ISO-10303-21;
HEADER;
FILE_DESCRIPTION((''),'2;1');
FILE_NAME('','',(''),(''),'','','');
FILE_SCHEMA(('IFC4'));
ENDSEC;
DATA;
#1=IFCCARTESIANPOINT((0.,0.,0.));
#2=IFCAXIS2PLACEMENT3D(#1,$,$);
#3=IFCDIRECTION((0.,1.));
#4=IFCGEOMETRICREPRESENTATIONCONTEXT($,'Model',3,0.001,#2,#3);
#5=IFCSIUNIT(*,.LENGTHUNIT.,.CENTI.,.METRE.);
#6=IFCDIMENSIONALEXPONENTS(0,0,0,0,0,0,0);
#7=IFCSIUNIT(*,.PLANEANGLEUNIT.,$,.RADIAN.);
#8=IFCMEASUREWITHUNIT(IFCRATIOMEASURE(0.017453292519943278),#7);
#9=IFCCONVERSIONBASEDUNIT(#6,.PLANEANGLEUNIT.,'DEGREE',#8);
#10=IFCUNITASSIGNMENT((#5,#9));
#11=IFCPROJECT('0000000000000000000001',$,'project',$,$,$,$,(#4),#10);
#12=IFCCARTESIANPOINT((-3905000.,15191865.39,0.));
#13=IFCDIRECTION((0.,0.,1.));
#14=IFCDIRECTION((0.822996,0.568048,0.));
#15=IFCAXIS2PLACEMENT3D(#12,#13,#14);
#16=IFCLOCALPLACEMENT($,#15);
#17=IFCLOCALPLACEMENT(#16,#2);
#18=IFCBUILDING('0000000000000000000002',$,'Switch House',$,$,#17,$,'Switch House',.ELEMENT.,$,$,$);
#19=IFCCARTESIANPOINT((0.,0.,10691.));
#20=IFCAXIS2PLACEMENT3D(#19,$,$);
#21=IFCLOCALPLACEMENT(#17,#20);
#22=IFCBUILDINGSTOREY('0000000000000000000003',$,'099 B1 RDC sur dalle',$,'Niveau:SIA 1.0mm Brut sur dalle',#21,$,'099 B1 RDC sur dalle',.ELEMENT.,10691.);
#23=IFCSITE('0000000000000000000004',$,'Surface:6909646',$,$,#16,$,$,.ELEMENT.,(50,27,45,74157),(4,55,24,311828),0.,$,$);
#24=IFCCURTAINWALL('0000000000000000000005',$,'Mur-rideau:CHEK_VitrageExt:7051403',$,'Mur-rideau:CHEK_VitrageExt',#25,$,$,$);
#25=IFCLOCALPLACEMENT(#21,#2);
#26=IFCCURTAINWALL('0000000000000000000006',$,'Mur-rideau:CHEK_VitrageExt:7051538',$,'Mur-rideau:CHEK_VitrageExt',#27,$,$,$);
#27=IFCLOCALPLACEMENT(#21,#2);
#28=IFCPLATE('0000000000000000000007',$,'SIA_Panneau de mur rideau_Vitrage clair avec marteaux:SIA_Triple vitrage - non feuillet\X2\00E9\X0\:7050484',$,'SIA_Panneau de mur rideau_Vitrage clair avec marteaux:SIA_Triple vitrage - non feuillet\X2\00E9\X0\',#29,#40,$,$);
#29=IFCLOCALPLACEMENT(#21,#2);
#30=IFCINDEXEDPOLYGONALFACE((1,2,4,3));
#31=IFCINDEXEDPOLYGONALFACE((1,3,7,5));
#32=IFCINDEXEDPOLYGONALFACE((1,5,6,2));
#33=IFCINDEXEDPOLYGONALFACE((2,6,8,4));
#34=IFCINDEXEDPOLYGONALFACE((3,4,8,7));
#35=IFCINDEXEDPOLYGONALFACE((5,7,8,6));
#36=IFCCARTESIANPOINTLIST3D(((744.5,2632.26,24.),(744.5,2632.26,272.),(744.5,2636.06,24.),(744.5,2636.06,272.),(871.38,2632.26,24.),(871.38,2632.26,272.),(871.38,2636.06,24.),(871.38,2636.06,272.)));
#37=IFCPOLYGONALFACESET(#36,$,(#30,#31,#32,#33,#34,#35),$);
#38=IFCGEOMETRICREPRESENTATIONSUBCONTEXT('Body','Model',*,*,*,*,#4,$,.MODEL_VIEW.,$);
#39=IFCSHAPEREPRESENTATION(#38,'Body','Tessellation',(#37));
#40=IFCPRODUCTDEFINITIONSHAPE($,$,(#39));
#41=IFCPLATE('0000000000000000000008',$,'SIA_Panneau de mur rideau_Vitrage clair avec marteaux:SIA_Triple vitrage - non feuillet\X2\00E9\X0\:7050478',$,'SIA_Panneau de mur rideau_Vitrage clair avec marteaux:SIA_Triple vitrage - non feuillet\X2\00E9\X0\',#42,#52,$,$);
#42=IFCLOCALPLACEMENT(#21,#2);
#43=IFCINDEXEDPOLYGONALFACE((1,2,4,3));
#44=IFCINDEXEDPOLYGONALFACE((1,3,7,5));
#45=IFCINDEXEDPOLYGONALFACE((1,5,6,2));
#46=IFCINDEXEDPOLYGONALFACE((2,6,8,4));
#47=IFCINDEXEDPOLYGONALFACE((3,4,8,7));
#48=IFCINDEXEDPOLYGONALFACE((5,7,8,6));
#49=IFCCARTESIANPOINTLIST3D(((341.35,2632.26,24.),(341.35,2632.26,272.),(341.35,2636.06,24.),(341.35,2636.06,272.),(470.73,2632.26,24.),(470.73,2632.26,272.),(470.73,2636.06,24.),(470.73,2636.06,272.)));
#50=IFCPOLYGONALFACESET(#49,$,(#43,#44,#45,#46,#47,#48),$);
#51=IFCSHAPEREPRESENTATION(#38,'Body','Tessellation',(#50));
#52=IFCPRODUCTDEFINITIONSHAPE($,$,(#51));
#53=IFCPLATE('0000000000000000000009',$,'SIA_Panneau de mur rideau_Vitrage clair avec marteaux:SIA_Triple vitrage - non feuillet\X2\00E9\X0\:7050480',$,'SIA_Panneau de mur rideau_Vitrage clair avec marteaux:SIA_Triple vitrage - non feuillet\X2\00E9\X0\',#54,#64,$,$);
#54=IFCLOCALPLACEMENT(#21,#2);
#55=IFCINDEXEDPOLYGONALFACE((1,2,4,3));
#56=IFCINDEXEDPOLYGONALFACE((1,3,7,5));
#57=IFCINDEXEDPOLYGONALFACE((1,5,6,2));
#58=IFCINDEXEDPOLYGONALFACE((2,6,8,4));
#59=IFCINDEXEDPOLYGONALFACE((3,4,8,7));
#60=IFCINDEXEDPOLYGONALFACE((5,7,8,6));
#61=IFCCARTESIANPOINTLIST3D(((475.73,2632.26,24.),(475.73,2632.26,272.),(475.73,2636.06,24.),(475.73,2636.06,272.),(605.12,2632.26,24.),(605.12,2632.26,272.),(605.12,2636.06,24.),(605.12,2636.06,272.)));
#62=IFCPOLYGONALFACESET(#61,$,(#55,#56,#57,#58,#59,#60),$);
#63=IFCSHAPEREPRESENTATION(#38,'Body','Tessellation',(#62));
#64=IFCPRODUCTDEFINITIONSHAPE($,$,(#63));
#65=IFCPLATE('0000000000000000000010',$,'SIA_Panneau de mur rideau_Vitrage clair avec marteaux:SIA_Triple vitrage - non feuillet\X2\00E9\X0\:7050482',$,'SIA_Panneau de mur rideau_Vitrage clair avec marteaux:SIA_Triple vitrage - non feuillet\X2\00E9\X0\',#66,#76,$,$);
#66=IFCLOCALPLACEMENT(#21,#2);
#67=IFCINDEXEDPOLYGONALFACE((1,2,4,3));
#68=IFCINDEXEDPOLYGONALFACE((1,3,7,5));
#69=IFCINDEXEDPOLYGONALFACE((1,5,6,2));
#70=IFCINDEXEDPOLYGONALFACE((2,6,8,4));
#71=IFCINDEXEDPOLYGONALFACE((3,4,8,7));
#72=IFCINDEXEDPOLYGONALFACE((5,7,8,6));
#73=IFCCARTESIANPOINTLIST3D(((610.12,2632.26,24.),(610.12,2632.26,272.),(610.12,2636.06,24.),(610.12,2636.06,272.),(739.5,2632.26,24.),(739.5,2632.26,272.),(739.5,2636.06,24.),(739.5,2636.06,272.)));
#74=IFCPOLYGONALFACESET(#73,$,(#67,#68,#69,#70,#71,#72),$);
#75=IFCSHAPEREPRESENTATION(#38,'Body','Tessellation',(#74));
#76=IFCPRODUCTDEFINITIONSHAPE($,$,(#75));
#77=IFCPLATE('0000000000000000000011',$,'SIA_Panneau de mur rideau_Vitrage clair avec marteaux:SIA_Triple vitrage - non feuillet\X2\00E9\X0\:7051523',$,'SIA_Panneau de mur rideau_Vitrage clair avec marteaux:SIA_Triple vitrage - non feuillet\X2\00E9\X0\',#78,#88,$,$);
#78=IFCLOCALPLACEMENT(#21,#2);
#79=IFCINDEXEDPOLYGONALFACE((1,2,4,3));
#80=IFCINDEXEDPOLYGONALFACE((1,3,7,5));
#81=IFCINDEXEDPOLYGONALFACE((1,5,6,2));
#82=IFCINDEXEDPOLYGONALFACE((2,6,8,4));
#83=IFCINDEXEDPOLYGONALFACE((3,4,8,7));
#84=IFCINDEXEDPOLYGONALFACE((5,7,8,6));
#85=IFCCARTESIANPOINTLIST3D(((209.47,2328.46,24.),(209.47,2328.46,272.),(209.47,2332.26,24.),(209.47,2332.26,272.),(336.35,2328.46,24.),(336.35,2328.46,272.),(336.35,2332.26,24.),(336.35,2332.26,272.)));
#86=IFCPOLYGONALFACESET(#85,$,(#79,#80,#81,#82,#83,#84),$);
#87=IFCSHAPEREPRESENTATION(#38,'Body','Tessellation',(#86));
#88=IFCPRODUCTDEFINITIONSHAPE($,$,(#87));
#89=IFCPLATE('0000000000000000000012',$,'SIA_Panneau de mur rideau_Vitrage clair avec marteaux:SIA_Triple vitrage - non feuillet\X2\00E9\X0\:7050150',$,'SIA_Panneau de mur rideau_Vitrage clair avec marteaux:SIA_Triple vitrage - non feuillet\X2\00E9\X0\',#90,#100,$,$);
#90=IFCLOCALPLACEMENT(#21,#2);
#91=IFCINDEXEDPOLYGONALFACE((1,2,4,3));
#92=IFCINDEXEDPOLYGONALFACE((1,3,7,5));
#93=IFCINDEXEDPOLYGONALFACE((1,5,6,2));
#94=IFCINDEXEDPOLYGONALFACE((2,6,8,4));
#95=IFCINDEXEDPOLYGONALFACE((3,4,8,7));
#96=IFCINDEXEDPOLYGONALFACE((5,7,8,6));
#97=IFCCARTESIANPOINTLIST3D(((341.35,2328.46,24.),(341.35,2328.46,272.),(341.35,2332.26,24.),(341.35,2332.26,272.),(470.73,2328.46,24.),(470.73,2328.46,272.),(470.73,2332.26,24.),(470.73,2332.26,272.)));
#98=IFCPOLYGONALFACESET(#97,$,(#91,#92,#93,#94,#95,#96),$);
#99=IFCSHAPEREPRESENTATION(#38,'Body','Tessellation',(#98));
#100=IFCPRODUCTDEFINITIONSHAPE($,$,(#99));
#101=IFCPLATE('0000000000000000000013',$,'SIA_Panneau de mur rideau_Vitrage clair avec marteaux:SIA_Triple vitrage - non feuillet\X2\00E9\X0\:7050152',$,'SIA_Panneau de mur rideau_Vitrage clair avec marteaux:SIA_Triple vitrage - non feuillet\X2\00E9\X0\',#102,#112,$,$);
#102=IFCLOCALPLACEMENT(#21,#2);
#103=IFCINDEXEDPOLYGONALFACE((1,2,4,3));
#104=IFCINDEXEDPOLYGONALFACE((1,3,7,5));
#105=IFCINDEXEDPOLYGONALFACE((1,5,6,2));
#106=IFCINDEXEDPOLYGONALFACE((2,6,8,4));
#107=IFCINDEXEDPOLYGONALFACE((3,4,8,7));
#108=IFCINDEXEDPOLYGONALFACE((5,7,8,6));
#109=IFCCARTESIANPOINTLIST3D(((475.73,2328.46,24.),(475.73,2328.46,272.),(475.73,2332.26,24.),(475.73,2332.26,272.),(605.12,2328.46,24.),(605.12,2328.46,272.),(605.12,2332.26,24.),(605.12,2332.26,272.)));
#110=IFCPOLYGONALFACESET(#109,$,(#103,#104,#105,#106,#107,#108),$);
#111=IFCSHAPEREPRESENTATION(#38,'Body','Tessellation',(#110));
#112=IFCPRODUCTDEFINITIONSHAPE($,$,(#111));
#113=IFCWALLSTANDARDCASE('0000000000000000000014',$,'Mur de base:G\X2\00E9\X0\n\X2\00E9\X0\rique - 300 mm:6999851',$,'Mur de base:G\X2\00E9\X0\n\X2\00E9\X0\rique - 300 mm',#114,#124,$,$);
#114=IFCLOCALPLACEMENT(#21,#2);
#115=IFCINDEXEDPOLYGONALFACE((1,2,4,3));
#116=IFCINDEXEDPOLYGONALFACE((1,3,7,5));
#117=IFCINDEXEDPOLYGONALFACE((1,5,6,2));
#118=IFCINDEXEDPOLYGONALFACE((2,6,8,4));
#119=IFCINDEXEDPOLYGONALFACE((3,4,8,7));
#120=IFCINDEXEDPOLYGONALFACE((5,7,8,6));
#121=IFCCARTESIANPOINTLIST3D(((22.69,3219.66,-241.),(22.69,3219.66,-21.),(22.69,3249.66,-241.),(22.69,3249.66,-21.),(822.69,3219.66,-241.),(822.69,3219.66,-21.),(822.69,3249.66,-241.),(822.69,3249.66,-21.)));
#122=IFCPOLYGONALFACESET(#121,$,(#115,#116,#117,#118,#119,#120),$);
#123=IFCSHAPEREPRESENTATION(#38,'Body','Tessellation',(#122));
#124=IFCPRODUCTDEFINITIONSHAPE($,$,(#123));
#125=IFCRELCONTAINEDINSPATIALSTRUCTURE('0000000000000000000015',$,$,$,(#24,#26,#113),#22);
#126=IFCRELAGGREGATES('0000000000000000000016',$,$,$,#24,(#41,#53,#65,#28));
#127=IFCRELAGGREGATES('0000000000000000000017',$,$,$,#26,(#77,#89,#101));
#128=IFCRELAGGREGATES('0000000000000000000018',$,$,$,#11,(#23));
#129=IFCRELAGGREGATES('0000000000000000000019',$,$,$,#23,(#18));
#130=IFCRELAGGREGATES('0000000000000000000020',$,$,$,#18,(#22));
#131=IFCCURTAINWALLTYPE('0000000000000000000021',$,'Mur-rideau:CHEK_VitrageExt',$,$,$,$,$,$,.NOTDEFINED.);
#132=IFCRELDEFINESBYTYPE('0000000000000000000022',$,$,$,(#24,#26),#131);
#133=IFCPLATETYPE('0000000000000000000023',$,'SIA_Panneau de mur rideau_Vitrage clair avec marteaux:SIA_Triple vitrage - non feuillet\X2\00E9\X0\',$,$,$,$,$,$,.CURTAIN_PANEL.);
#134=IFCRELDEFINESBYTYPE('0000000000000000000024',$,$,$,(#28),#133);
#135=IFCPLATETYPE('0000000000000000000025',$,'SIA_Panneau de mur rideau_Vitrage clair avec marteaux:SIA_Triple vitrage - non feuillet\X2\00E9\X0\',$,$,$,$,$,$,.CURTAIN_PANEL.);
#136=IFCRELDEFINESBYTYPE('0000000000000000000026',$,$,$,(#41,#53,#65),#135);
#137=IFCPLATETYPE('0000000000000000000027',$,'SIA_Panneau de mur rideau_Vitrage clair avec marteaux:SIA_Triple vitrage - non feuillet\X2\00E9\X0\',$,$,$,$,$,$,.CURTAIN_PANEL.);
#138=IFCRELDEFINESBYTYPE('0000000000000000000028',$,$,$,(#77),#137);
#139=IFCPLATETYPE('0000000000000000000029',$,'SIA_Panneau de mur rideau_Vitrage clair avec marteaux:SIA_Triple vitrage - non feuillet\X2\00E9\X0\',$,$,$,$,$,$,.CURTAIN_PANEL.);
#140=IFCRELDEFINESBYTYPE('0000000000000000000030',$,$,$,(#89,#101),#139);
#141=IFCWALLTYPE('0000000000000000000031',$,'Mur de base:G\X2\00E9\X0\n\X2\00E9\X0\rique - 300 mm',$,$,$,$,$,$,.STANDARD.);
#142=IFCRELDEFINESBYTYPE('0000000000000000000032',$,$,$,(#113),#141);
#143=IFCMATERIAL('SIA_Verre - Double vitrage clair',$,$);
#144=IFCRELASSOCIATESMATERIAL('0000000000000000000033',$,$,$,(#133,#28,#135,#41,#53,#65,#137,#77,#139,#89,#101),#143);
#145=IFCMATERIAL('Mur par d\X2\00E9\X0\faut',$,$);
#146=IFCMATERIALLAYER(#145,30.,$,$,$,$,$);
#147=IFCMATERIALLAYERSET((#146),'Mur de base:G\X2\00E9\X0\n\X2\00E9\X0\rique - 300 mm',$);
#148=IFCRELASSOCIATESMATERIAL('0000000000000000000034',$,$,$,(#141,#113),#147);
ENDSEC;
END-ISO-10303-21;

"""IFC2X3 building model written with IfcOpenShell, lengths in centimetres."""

from ifc_helpers import new_model, entity, si_unit, converted_unit, direction, frame, frame_2d, origin, origin_2d_with_axis, place, context, subcontext, project, spatial, rectangle, extrude, source, transform, mapped, material, layer, layer_set, layer_usage, type_object, type_shapes, element, aggregate, save


model = new_model("IFC2X3")

# Units and contexts
model_context = context("Model", 3, precision=0.001, world=origin(), true_north=direction((0.0, 1.0)))
body_context = subcontext(model_context, "Body", "Model", "MODEL_VIEW")
ifc_project = project(units=[si_unit("LENGTHUNIT", "METRE", prefix="CENTI"), converted_unit("PLANEANGLEUNIT", "DEGREE", entity("IfcRatioMeasure", 0.017453292519943278), si_unit("PLANEANGLEUNIT", "RADIAN"), dimensions=[0, 0, 0, 0, 0, 0, 0])], contexts=[model_context])

# Site, building, storey
site_placement = place(None, frame((-3905000.0, 15191865.39, 0.0), z_axis=(0.0, 0.0, 1.0), x_axis=(0.822996, 0.568048, 0.0)))
site = spatial("IfcSite", under=ifc_project, at=site_placement, Name="Surface:6909646", CompositionType="ELEMENT", RefLatitude=(50, 27, 45, 74157), RefLongitude=(4, 55, 24, 311828), RefElevation=0.0)
building_placement = place(site_placement, origin())
building = spatial("IfcBuilding", under=site, at=building_placement, Name="Switch House", LongName="Switch House", CompositionType="ELEMENT")
storey_placement = place(building_placement, frame((0.0, 0.0, 10691.0)))
storey = spatial("IfcBuildingStorey", under=building, at=storey_placement, Name="099 B1 RDC sur dalle", ObjectType="Niveau:SIA 1.0mm Brut sur dalle", LongName="099 B1 RDC sur dalle", CompositionType="ELEMENT", Elevation=10691.0)

# Shared definitions
curtain_wall_type = type_object("IfcCurtainWallType", Name="Mur-rideau:CHEK_VitrageExt", PredefinedType="NOTDEFINED")

# Curtain walls
curtain_wall_1_placement = place(storey_placement, frame((0.0, 0.0, -10691.0)))
curtain_wall_1 = element("IfcCurtainWall", 1, at=curtain_wall_1_placement, inside=storey, type_object=curtain_wall_type, Name="Mur-rideau:CHEK_VitrageExt:7051403", ObjectType="Mur-rideau:CHEK_VitrageExt")
curtain_wall_2_placement = place(storey_placement, frame((0.0, 0.0, -10691.0)))
curtain_wall_2 = element("IfcCurtainWall", 2, at=curtain_wall_2_placement, inside=storey, type_object=curtain_wall_type, Name="Mur-rideau:CHEK_VitrageExt:7051538", ObjectType="Mur-rideau:CHEK_VitrageExt")

# Plates
ifc_material_1 = material(Name="SIA_Verre - Double vitrage clair")
plate_type_1 = type_object("IfcPlateType", Name="SIA_Panneau de mur rideau_Vitrage clair avec marteaux:SIA_Triple vitrage - non feuilleté", PredefinedType="CURTAIN_PANEL", material=ifc_material_1)
shared_shape_1 = source(origin(), body_context, "Body", "SweptSolid", [
    extrude(rectangle(XDim=126.88, YDim=3.8, at=origin_2d_with_axis()), frame((0.0, 1.9, 0.0), z_axis=(0.0, 0.0, 1.0), x_axis=(-1.0, 0.0, 0.0)), (0.0, 0.0, 1.0), 248.0),
])
type_shapes(plate_type_1, [shared_shape_1])
plate_1_placement = place(curtain_wall_1_placement, frame((807.94, 2632.26, 10715.0)))
plate_1 = element("IfcPlate", 3, at=plate_1_placement, type_object=plate_type_1, material=ifc_material_1, Name="SIA_Panneau de mur rideau_Vitrage clair avec marteaux:SIA_Triple vitrage - non feuilleté:7050484", ObjectType="SIA_Panneau de mur rideau_Vitrage clair avec marteaux:SIA_Triple vitrage - non feuilleté", context=body_context, shape_type="MappedRepresentation", body=[
    mapped(shared_shape_1, transform((0.0, 0.0, 0.0), scale=1.0)),
])
plate_type_2 = type_object("IfcPlateType", Name="SIA_Panneau de mur rideau_Vitrage clair avec marteaux:SIA_Triple vitrage - non feuilleté", PredefinedType="CURTAIN_PANEL", material=ifc_material_1)
shared_shape_2 = source(origin(), body_context, "Body", "SweptSolid", [
    extrude(rectangle(XDim=129.38, YDim=3.8, at=origin_2d_with_axis()), frame((0.0, 1.9, 0.0), z_axis=(0.0, 0.0, 1.0), x_axis=(-1.0, 0.0, 0.0)), (0.0, 0.0, 1.0), 248.0),
])
type_shapes(plate_type_2, [shared_shape_2])
plate_2_placement = place(curtain_wall_1_placement, frame((406.04, 2632.26, 10715.0)))
plate_2 = element("IfcPlate", 4, at=plate_2_placement, type_object=plate_type_2, material=ifc_material_1, Name="SIA_Panneau de mur rideau_Vitrage clair avec marteaux:SIA_Triple vitrage - non feuilleté:7050478", ObjectType="SIA_Panneau de mur rideau_Vitrage clair avec marteaux:SIA_Triple vitrage - non feuilleté", context=body_context, shape_type="MappedRepresentation", body=[
    mapped(shared_shape_2, transform((0.0, 0.0, 0.0), scale=1.0)),
])
plate_3_placement = place(curtain_wall_1_placement, frame((540.43, 2632.26, 10715.0)))
plate_3 = element("IfcPlate", 5, at=plate_3_placement, type_object=plate_type_2, material=ifc_material_1, Name="SIA_Panneau de mur rideau_Vitrage clair avec marteaux:SIA_Triple vitrage - non feuilleté:7050480", ObjectType="SIA_Panneau de mur rideau_Vitrage clair avec marteaux:SIA_Triple vitrage - non feuilleté", context=body_context, shape_type="MappedRepresentation", body=[
    mapped(shared_shape_2, transform((0.0, 0.0, 0.0), scale=1.0)),
])
plate_4_placement = place(curtain_wall_1_placement, frame((674.81, 2632.26, 10715.0)))
plate_4 = element("IfcPlate", 6, at=plate_4_placement, type_object=plate_type_2, material=ifc_material_1, Name="SIA_Panneau de mur rideau_Vitrage clair avec marteaux:SIA_Triple vitrage - non feuilleté:7050482", ObjectType="SIA_Panneau de mur rideau_Vitrage clair avec marteaux:SIA_Triple vitrage - non feuilleté", context=body_context, shape_type="MappedRepresentation", body=[
    mapped(shared_shape_2, transform((0.0, 0.0, 0.0), scale=1.0)),
])
aggregate(curtain_wall_1, [plate_2, plate_3, plate_4, plate_1])
plate_type_3 = type_object("IfcPlateType", Name="SIA_Panneau de mur rideau_Vitrage clair avec marteaux:SIA_Triple vitrage - non feuilleté", PredefinedType="CURTAIN_PANEL", material=ifc_material_1)
shared_shape_3 = source(origin(), body_context, "Body", "SweptSolid", [
    extrude(rectangle(XDim=3.8, YDim=126.88, at=origin_2d_with_axis()), frame((0.0, -1.9, 0.0), z_axis=(0.0, 0.0, 1.0), x_axis=(0.0, 1.0, 0.0)), (0.0, 0.0, 1.0), 248.0),
])
type_shapes(plate_type_3, [shared_shape_3])
plate_5_placement = place(curtain_wall_2_placement, frame((272.91, 2332.26, 10715.0)))
plate_5 = element("IfcPlate", 7, at=plate_5_placement, type_object=plate_type_3, material=ifc_material_1, Name="SIA_Panneau de mur rideau_Vitrage clair avec marteaux:SIA_Triple vitrage - non feuilleté:7051523", ObjectType="SIA_Panneau de mur rideau_Vitrage clair avec marteaux:SIA_Triple vitrage - non feuilleté", context=body_context, shape_type="MappedRepresentation", body=[
    mapped(shared_shape_3, transform((0.0, 0.0, 0.0), scale=1.0)),
])
plate_type_4 = type_object("IfcPlateType", Name="SIA_Panneau de mur rideau_Vitrage clair avec marteaux:SIA_Triple vitrage - non feuilleté", PredefinedType="CURTAIN_PANEL", material=ifc_material_1)
shared_shape_4 = source(origin(), body_context, "Body", "SweptSolid", [
    extrude(rectangle(XDim=3.8, YDim=129.38, at=origin_2d_with_axis()), frame((0.0, -1.9, 0.0), z_axis=(0.0, 0.0, 1.0), x_axis=(0.0, 1.0, 0.0)), (0.0, 0.0, 1.0), 248.0),
])
type_shapes(plate_type_4, [shared_shape_4])
plate_6_placement = place(curtain_wall_2_placement, frame((406.04, 2332.26, 10715.0)))
plate_6 = element("IfcPlate", 8, at=plate_6_placement, type_object=plate_type_4, material=ifc_material_1, Name="SIA_Panneau de mur rideau_Vitrage clair avec marteaux:SIA_Triple vitrage - non feuilleté:7050150", ObjectType="SIA_Panneau de mur rideau_Vitrage clair avec marteaux:SIA_Triple vitrage - non feuilleté", context=body_context, shape_type="MappedRepresentation", body=[
    mapped(shared_shape_4, transform((0.0, 0.0, 0.0), scale=1.0)),
])
plate_7_placement = place(curtain_wall_2_placement, frame((540.43, 2332.26, 10715.0)))
plate_7 = element("IfcPlate", 9, at=plate_7_placement, type_object=plate_type_4, material=ifc_material_1, Name="SIA_Panneau de mur rideau_Vitrage clair avec marteaux:SIA_Triple vitrage - non feuilleté:7050152", ObjectType="SIA_Panneau de mur rideau_Vitrage clair avec marteaux:SIA_Triple vitrage - non feuilleté", context=body_context, shape_type="MappedRepresentation", body=[
    mapped(shared_shape_4, transform((0.0, 0.0, 0.0), scale=1.0)),
])
aggregate(curtain_wall_2, [plate_5, plate_6, plate_7])

# Wall
ifc_material_2 = material(Name="Mur par défaut")
ifc_layer = layer(ifc_material_2, 30.0)
ifc_layer_set = layer_set([ifc_layer], Name="Mur de base:Générique - 300 mm")
ifc_layer_usage = layer_usage(ifc_layer_set, "AXIS2", "NEGATIVE", 15.0)
wall_type = type_object("IfcWallType", Name="Mur de base:Générique - 300 mm", PredefinedType="STANDARD", material=ifc_layer_set)
wall_placement = place(storey_placement, frame((822.69, 3234.66, -241.0), z_axis=(0.0, 0.0, 1.0), x_axis=(-1.0, 0.0, 0.0)))
element("IfcWallStandardCase", 10, at=wall_placement, inside=storey, type_object=wall_type, material=ifc_layer_usage, Name="Mur de base:Générique - 300 mm:6999851", ObjectType="Mur de base:Générique - 300 mm", context=body_context, shape_type="SweptSolid", body=[
    extrude(rectangle(XDim=800.0, YDim=30.0, at=frame_2d((400.0, 0.0), x_axis=(-1.0, 0.0))), origin(), (0.0, 0.0, 1.0), 220.0),
])

save(model, "model.ifc")
